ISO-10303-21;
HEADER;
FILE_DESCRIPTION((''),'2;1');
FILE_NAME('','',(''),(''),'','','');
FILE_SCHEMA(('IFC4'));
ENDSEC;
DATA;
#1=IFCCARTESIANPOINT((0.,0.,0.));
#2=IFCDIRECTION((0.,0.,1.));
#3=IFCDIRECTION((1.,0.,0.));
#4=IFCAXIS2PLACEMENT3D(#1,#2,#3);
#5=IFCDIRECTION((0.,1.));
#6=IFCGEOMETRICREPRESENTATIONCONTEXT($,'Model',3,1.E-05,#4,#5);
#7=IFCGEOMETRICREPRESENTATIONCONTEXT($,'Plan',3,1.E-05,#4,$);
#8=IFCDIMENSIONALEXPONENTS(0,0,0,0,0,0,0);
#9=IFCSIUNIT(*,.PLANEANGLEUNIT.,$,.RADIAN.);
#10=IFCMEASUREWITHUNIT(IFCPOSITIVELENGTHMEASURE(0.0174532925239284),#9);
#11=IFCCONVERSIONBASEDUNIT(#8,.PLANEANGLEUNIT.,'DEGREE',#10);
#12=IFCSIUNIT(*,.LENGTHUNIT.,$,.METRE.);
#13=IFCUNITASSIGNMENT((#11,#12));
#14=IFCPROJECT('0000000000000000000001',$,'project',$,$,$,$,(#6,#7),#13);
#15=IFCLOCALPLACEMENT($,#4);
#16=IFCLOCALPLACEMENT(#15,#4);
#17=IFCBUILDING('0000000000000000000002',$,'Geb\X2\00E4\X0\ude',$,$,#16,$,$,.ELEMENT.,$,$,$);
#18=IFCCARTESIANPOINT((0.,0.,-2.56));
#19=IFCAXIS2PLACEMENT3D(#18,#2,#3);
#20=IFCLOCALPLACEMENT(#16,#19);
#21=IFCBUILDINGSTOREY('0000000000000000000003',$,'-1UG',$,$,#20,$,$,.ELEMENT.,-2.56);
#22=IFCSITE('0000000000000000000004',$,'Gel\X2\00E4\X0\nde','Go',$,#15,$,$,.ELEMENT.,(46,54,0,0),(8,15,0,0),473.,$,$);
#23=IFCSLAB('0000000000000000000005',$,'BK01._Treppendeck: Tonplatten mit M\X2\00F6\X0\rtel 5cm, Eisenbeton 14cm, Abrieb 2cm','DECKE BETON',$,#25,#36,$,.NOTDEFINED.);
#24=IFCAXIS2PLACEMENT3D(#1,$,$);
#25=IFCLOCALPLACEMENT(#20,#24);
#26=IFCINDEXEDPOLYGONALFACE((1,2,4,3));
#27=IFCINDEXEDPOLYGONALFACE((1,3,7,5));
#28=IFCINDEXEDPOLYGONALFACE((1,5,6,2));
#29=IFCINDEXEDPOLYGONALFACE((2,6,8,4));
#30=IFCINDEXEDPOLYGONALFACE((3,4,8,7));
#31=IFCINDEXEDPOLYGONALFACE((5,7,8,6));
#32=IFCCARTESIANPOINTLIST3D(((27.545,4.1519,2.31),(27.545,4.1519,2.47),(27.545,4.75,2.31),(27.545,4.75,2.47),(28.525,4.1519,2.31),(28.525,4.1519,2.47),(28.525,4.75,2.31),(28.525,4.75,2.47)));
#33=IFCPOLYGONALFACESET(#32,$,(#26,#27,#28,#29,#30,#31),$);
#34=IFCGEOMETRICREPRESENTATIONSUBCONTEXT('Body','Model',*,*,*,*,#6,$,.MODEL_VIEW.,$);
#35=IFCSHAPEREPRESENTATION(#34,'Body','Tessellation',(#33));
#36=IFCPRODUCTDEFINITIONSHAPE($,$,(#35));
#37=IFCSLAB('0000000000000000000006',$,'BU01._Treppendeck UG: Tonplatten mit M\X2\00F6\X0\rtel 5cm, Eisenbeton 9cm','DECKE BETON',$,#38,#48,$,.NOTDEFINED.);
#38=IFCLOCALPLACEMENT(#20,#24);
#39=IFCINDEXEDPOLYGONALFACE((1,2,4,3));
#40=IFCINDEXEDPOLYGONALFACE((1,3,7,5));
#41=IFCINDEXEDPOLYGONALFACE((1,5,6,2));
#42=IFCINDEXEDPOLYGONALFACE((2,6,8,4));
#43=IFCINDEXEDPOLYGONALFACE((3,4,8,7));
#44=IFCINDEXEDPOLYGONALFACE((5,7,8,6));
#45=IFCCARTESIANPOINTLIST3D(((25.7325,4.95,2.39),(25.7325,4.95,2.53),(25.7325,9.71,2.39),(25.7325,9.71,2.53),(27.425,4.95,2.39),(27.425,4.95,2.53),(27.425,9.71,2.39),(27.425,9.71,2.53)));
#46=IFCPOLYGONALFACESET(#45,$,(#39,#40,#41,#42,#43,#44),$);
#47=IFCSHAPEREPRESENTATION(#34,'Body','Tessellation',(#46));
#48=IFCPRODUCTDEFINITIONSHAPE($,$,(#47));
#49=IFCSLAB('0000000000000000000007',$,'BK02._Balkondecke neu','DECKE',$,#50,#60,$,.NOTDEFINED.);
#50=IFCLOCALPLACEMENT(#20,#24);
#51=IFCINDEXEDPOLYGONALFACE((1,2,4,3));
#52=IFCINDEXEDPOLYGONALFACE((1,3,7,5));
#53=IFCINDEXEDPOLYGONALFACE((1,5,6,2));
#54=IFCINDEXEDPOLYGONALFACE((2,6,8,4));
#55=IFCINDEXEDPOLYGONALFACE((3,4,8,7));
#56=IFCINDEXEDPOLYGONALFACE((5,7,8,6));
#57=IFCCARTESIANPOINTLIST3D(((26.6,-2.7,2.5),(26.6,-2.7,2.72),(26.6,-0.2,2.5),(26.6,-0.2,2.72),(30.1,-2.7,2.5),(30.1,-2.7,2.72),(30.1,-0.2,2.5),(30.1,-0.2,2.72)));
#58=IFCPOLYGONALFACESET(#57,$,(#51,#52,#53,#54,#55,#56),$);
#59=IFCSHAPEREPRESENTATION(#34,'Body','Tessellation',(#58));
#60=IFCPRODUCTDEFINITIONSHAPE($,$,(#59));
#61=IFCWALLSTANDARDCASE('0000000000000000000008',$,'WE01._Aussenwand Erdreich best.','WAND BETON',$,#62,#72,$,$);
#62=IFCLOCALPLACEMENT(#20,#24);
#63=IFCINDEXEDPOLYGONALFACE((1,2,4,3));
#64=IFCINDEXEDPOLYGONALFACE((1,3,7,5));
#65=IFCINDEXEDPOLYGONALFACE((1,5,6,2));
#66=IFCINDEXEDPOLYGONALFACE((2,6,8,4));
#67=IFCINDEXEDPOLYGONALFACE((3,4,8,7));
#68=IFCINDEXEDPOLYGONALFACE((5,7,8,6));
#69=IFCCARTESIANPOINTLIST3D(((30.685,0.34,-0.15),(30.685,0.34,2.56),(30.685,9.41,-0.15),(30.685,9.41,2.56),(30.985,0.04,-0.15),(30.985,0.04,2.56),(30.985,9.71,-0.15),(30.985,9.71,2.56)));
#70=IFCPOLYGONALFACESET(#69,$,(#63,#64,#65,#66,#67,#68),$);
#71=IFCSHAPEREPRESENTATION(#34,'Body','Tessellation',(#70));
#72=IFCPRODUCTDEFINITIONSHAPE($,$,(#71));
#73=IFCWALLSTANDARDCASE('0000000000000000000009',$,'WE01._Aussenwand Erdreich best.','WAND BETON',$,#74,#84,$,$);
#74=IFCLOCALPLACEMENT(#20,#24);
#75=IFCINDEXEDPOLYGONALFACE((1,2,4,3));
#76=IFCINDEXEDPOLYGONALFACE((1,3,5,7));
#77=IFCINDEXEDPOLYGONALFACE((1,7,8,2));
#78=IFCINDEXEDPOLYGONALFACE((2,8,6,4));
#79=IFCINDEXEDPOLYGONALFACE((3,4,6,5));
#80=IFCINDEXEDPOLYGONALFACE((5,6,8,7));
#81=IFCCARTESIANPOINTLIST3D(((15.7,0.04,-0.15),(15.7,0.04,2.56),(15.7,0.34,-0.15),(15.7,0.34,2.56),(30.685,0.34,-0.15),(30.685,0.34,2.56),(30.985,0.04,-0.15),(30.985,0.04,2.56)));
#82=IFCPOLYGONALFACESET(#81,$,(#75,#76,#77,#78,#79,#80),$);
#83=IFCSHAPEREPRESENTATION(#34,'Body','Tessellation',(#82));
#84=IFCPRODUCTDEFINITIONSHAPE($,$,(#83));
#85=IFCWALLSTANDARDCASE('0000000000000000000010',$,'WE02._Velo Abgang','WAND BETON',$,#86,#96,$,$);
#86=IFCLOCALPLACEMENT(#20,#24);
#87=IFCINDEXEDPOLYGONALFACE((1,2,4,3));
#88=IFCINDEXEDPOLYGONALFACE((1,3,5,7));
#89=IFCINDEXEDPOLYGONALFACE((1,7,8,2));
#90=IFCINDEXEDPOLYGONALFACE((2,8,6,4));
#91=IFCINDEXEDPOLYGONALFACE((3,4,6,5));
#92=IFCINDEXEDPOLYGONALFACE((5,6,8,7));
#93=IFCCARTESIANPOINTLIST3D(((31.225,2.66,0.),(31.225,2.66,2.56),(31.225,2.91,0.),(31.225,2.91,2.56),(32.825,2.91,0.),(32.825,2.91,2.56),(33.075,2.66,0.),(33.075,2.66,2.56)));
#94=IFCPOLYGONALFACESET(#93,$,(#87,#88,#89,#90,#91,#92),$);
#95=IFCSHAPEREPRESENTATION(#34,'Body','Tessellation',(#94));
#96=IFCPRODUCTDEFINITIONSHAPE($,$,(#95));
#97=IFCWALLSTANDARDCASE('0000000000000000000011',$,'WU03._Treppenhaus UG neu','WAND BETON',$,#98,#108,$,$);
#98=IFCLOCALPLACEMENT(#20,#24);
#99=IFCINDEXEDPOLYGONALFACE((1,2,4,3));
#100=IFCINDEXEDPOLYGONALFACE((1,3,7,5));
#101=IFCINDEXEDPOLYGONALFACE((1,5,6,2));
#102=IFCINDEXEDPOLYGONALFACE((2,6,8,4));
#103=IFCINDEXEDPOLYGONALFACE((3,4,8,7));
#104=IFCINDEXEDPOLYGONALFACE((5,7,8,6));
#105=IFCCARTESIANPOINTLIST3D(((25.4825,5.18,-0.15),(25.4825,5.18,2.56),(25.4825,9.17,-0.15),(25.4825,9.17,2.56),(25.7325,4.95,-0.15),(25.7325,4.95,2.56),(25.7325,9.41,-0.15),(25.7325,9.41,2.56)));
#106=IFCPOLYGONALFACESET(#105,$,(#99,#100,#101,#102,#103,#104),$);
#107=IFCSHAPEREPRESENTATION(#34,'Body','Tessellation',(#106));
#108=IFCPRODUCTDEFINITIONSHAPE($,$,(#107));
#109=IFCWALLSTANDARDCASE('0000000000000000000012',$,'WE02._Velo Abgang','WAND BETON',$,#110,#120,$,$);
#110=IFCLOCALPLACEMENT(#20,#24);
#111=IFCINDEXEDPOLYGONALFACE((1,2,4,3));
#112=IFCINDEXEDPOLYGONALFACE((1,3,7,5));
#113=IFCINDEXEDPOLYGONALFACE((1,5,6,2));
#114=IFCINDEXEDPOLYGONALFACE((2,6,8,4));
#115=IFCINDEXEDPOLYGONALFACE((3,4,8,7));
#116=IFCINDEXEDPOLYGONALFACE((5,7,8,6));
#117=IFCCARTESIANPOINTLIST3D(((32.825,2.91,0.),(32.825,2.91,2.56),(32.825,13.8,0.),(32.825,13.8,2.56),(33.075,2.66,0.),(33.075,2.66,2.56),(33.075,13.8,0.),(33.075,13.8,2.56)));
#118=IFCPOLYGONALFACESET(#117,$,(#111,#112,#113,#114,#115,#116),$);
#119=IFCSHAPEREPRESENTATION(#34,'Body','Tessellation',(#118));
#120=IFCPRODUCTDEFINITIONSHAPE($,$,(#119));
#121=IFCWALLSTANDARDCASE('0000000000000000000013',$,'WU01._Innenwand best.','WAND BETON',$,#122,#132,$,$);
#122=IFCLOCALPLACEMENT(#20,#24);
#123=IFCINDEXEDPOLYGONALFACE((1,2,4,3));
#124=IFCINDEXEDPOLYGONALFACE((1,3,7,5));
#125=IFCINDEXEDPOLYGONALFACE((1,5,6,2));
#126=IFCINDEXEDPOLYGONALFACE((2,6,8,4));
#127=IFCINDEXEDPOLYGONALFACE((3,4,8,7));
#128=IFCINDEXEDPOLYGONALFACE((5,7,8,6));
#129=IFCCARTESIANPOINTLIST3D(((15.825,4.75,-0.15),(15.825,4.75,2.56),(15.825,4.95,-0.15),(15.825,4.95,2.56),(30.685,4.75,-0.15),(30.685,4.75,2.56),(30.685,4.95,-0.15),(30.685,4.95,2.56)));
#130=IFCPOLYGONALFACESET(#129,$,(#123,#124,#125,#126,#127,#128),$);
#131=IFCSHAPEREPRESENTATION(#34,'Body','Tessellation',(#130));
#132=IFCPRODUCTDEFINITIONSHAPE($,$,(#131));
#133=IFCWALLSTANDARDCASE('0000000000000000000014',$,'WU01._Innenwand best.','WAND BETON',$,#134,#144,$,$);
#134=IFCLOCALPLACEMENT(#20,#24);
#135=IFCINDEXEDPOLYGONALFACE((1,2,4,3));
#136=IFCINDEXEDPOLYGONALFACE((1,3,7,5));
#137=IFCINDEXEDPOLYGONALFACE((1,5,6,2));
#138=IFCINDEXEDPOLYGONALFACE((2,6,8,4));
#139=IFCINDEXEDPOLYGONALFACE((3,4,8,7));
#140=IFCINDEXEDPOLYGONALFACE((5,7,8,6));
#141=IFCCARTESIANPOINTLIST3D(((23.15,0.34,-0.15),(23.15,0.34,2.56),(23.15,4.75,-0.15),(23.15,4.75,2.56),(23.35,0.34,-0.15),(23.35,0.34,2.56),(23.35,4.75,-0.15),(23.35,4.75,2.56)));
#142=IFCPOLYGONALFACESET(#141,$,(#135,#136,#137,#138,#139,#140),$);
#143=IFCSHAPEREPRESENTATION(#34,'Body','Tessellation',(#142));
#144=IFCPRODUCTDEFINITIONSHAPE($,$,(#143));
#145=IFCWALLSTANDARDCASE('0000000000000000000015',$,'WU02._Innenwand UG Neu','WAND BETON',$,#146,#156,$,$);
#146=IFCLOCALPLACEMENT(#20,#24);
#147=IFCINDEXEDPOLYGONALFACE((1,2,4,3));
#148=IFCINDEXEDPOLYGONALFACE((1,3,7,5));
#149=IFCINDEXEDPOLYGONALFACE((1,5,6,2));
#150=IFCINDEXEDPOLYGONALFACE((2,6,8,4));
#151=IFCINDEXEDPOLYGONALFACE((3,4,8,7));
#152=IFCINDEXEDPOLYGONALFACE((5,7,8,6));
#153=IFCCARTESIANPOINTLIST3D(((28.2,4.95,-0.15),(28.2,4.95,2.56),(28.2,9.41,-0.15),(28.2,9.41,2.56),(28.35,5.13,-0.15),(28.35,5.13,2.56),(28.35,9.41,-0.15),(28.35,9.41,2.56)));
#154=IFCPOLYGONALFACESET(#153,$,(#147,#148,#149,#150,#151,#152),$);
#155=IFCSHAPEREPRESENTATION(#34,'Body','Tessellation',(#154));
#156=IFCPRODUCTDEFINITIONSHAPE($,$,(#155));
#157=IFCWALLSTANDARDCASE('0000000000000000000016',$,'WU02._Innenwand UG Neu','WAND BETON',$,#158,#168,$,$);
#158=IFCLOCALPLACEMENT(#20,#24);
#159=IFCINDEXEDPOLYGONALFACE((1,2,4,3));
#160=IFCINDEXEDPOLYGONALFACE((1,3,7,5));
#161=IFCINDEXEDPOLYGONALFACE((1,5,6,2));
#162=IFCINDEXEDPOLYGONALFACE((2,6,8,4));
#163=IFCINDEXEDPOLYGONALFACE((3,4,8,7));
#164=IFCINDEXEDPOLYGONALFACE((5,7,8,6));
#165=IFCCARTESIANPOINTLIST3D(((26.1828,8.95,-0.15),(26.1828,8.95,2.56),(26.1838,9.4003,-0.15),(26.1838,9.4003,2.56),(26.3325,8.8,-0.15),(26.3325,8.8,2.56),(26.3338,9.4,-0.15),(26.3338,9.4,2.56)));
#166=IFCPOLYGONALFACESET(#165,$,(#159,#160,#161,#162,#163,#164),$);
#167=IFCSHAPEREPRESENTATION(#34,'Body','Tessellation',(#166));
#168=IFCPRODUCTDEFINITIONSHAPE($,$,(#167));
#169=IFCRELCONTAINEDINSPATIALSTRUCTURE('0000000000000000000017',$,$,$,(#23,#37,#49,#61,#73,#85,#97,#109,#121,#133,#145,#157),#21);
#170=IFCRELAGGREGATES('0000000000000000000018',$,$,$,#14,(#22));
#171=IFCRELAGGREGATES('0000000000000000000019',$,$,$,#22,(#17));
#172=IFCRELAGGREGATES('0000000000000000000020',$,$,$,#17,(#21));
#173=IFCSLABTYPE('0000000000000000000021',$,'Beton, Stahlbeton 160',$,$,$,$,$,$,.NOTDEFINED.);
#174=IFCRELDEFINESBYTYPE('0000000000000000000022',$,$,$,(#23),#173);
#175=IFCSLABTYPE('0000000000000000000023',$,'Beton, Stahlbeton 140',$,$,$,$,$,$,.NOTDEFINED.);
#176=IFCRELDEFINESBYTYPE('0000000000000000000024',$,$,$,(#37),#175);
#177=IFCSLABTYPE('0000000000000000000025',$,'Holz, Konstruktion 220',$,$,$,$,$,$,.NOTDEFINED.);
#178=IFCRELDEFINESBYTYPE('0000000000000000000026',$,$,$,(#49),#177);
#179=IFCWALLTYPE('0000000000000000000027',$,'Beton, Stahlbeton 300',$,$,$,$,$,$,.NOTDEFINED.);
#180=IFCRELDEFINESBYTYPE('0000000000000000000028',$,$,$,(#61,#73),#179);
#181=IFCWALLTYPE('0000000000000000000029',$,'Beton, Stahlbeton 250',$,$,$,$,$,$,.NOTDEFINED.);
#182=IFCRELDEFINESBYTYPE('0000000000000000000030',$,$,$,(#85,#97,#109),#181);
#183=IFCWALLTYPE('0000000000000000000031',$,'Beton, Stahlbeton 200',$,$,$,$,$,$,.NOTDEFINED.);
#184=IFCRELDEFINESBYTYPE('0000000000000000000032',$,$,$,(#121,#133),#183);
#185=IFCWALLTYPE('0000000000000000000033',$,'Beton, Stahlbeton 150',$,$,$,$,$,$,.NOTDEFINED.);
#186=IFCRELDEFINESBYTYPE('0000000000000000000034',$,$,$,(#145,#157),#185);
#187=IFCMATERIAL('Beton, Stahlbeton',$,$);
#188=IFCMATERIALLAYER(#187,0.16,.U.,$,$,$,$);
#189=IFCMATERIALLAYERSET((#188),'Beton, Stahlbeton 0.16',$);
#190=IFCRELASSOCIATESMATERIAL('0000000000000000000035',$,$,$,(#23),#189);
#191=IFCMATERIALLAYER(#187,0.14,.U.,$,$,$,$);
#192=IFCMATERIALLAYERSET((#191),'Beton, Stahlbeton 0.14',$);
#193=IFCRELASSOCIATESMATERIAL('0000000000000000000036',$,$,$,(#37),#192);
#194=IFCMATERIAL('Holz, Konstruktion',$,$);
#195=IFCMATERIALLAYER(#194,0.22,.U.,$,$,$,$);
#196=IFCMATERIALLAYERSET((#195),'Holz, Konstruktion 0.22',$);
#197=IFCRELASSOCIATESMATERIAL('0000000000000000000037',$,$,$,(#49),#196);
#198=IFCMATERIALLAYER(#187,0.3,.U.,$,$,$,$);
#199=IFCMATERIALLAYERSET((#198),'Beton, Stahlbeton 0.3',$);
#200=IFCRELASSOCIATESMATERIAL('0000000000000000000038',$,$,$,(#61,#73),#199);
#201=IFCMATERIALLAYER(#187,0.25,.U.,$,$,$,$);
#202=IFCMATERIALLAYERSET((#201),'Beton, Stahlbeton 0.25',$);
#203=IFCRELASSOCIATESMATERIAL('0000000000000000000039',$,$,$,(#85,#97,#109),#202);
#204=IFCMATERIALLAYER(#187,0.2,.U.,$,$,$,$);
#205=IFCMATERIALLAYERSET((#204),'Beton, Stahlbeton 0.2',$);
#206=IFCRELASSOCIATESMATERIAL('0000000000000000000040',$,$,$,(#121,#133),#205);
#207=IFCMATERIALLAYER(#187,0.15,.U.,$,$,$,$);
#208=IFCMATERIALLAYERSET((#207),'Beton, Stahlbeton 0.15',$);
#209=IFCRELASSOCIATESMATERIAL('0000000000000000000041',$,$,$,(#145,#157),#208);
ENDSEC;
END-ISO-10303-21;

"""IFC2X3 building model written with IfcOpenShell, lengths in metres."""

from ifc_helpers import new_model, entity, si_unit, converted_unit, direction, frame, origin_with_axes, place, context, subcontext, project, spatial, polyline, outline, extrude, material, layer, layer_set, layer_usage, type_object, element, save


model = new_model("IFC2X3")

# Units and contexts
model_context = context("Model", 3, precision=1e-05, world=origin_with_axes(), true_north=direction((0.0, 1.0)))
plan_context = context("Plan", 3, precision=1e-05, world=origin_with_axes())
body_context = subcontext(model_context, "Body", "Model", "MODEL_VIEW")
ifc_project = project(units=[converted_unit("PLANEANGLEUNIT", "DEGREE", entity("IfcPositiveLengthMeasure", 0.0174532925239284), si_unit("PLANEANGLEUNIT", "RADIAN"), dimensions=[0, 0, 0, 0, 0, 0, 0]), si_unit("LENGTHUNIT", "METRE")], contexts=[model_context, plan_context])

# Site, building, storey
site_placement = place(None, origin_with_axes())
site = spatial("IfcSite", under=ifc_project, at=site_placement, Name="Gelände", Description="Go", CompositionType="ELEMENT", RefLatitude=(46, 54, 0, 0), RefLongitude=(8, 15, 0, 0), RefElevation=473.0)
building_placement = place(site_placement, origin_with_axes())
building = spatial("IfcBuilding", under=site, at=building_placement, Name="Gebäude", CompositionType="ELEMENT")
storey_placement = place(building_placement, frame((0.0, 0.0, -2.56), z_axis=(0.0, 0.0, 1.0), x_axis=(1.0, 0.0, 0.0)))
storey = spatial("IfcBuildingStorey", under=building, at=storey_placement, Name="-1UG", CompositionType="ELEMENT", Elevation=-2.56)

# Slabs
ifc_material_1 = material(Name="Beton, Stahlbeton")
ifc_layer_1 = layer(ifc_material_1, 0.16, ventilated="UNKNOWN")
ifc_layer_set_1 = layer_set([ifc_layer_1], Name="Beton, Stahlbeton 0.16")
ifc_layer_usage_1 = layer_usage(ifc_layer_set_1, "AXIS3", "NEGATIVE", 0.16)
slab_type_1 = type_object("IfcSlabType", Name="Beton, Stahlbeton 160", PredefinedType="NOTDEFINED")
slab_1_placement = place(storey_placement, frame((27.545, 4.1519, 2.47), z_axis=(0.0, 0.0, 1.0), x_axis=(1.0, 0.0, 0.0)))
element("IfcSlab", 1, at=slab_1_placement, inside=storey, type_object=slab_type_1, material=ifc_layer_usage_1, Name="BK01._Treppendeck: Tonplatten mit Mörtel 5cm, Eisenbeton 14cm, Abrieb 2cm", Description="DECKE BETON", PredefinedType="NOTDEFINED", context=body_context, shape_type="SweptSolid", body=[
    extrude(outline(polyline([(0.0, 0.0), (0.98, 0.0), (0.98, 0.5981), (0.0, 0.5981), (0.0, 0.0)])), frame((0.0, 0.0, -0.16), z_axis=(0.0, 0.0, 1.0), x_axis=(1.0, 0.0, 0.0)), (0.0, 0.0, 1.0), 0.16),
])
ifc_layer_2 = layer(ifc_material_1, 0.14, ventilated="UNKNOWN")
ifc_layer_set_2 = layer_set([ifc_layer_2], Name="Beton, Stahlbeton 0.14")
ifc_layer_usage_2 = layer_usage(ifc_layer_set_2, "AXIS3", "NEGATIVE", 0.14)
slab_type_2 = type_object("IfcSlabType", Name="Beton, Stahlbeton 140", PredefinedType="NOTDEFINED")
slab_2_placement = place(storey_placement, frame((25.7325, 4.95, 2.53), z_axis=(0.0, 0.0, 1.0), x_axis=(1.0, 0.0, 0.0)))
element("IfcSlab", 2, at=slab_2_placement, inside=storey, type_object=slab_type_2, material=ifc_layer_usage_2, Name="BU01._Treppendeck UG: Tonplatten mit Mörtel 5cm, Eisenbeton 9cm", Description="DECKE BETON", PredefinedType="NOTDEFINED", context=body_context, shape_type="SweptSolid", body=[
    extrude(outline(polyline([(0.0, 0.0), (1.6925, 0.0), (1.6925, 4.76), (0.0, 4.76), (0.0, 0.0)])), frame((0.0, 0.0, -0.14), z_axis=(0.0, 0.0, 1.0), x_axis=(1.0, 0.0, 0.0)), (0.0, 0.0, 1.0), 0.14),
])
ifc_material_2 = material(Name="Holz, Konstruktion")
ifc_layer_3 = layer(ifc_material_2, 0.22, ventilated="UNKNOWN")
ifc_layer_set_3 = layer_set([ifc_layer_3], Name="Holz, Konstruktion 0.22")
ifc_layer_usage_3 = layer_usage(ifc_layer_set_3, "AXIS3", "NEGATIVE", 0.22)
slab_type_3 = type_object("IfcSlabType", Name="Holz, Konstruktion 220", PredefinedType="NOTDEFINED")
slab_3_placement = place(storey_placement, frame((26.6, -2.7, 2.72), z_axis=(0.0, 0.0, 1.0), x_axis=(1.0, 0.0, 0.0)))
element("IfcSlab", 3, at=slab_3_placement, inside=storey, type_object=slab_type_3, material=ifc_layer_usage_3, Name="BK02._Balkondecke neu", Description="DECKE", PredefinedType="NOTDEFINED", context=body_context, shape_type="SweptSolid", body=[
    extrude(outline(polyline([(0.0, 0.0), (3.5, 0.0), (3.5, 2.5), (0.0, 2.5), (0.0, 0.0)])), frame((0.0, 0.0, -0.22), z_axis=(0.0, 0.0, 1.0), x_axis=(1.0, 0.0, 0.0)), (0.0, 0.0, 1.0), 0.22),
])

# Walls
ifc_layer_4 = layer(ifc_material_1, 0.3, ventilated="UNKNOWN")
ifc_layer_set_4 = layer_set([ifc_layer_4], Name="Beton, Stahlbeton 0.3")
ifc_layer_usage_4 = layer_usage(ifc_layer_set_4, "AXIS2", "NEGATIVE", 0.3)
wall_type_1 = type_object("IfcWallType", Name="Beton, Stahlbeton 300", PredefinedType="NOTDEFINED")
wall_1_placement = place(storey_placement, frame((30.685, 9.41, -0.15), z_axis=(0.0, 0.0, 1.0), x_axis=(0.0, -1.0, 0.0)))
element("IfcWallStandardCase", 4, at=wall_1_placement, inside=storey, type_object=wall_type_1, material=ifc_layer_usage_4, Name="WE01._Aussenwand Erdreich best.", Description="WAND BETON", context=body_context, shape_type="SweptSolid", body=[
    extrude(outline(polyline([(0.0, 0.0), (9.07, 0.0), (9.37, 0.3), (-0.3, 0.3), (0.0, 0.0)])), origin_with_axes(), (0.0, 0.0, 1.0), 2.71),
])
ifc_layer_usage_5 = layer_usage(ifc_layer_set_4, "AXIS2", "NEGATIVE", 0.3)
wall_2_placement = place(storey_placement, frame((30.685, 0.34, -0.15), z_axis=(0.0, 0.0, 1.0), x_axis=(-1.0, 0.0, 0.0)))
element("IfcWallStandardCase", 5, at=wall_2_placement, inside=storey, type_object=wall_type_1, material=ifc_layer_usage_5, Name="WE01._Aussenwand Erdreich best.", Description="WAND BETON", context=body_context, shape_type="SweptSolid", body=[
    extrude(outline(polyline([(0.0, 0.0), (14.985, 0.0), (14.985, 0.3), (-0.3, 0.3), (0.0, 0.0)])), origin_with_axes(), (0.0, 0.0, 1.0), 2.71),
])
ifc_layer_5 = layer(ifc_material_1, 0.25, ventilated="UNKNOWN")
ifc_layer_set_5 = layer_set([ifc_layer_5], Name="Beton, Stahlbeton 0.25")
ifc_layer_usage_6 = layer_usage(ifc_layer_set_5, "AXIS2", "NEGATIVE", 0.0)
wall_type_2 = type_object("IfcWallType", Name="Beton, Stahlbeton 250", PredefinedType="NOTDEFINED")
wall_3_placement = place(storey_placement, frame((33.075, 2.66, 0.0), z_axis=(0.0, 0.0, 1.0), x_axis=(-1.0, 0.0, 0.0)))
element("IfcWallStandardCase", 6, at=wall_3_placement, inside=storey, type_object=wall_type_2, material=ifc_layer_usage_6, Name="WE02._Velo Abgang", Description="WAND BETON", context=body_context, shape_type="SweptSolid", body=[
    extrude(outline(polyline([(0.25, -0.25), (1.85, -0.25), (1.85, 0.0), (0.0, 0.0), (0.25, -0.25)])), origin_with_axes(), (0.0, 0.0, 1.0), 2.56),
])
ifc_layer_usage_7 = layer_usage(ifc_layer_set_5, "AXIS2", "NEGATIVE", 0.25)
wall_4_placement = place(storey_placement, frame((25.4825, 9.17, -0.15), z_axis=(0.0, 0.0, 1.0), x_axis=(0.0, -1.0, 0.0)))
element("IfcWallStandardCase", 7, at=wall_4_placement, inside=storey, type_object=wall_type_2, material=ifc_layer_usage_7, Name="WU03._Treppenhaus UG neu", Description="WAND BETON", context=body_context, shape_type="SweptSolid", body=[
    extrude(outline(polyline([(0.0, 0.0), (3.99, 0.0), (4.22, 0.25), (-0.24, 0.25), (0.0, 0.0)])), origin_with_axes(), (0.0, 0.0, 1.0), 2.71),
])
ifc_layer_usage_8 = layer_usage(ifc_layer_set_5, "AXIS2", "NEGATIVE", 0.0)
wall_5_placement = place(storey_placement, frame((33.075, 13.8, 0.0), z_axis=(0.0, 0.0, 1.0), x_axis=(0.0, -1.0, 0.0)))
element("IfcWallStandardCase", 8, at=wall_5_placement, inside=storey, type_object=wall_type_2, material=ifc_layer_usage_8, Name="WE02._Velo Abgang", Description="WAND BETON", context=body_context, shape_type="SweptSolid", body=[
    extrude(outline(polyline([(0.0, -0.25), (10.89, -0.25), (11.14, 0.0), (0.0, 0.0), (0.0, -0.25)])), origin_with_axes(), (0.0, 0.0, 1.0), 2.56),
])
ifc_layer_6 = layer(ifc_material_1, 0.2, ventilated="UNKNOWN")
ifc_layer_set_6 = layer_set([ifc_layer_6], Name="Beton, Stahlbeton 0.2")
ifc_layer_usage_9 = layer_usage(ifc_layer_set_6, "AXIS2", "POSITIVE", 0.0)
wall_type_3 = type_object("IfcWallType", Name="Beton, Stahlbeton 200", PredefinedType="NOTDEFINED")
wall_6_placement = place(storey_placement, frame((30.685, 4.95, -0.15), z_axis=(0.0, 0.0, 1.0), x_axis=(-1.0, 0.0, 0.0)))
element("IfcWallStandardCase", 9, at=wall_6_placement, inside=storey, type_object=wall_type_3, material=ifc_layer_usage_9, Name="WU01._Innenwand best.", Description="WAND BETON", context=body_context, shape_type="SweptSolid", body=[
    extrude(outline(polyline([(0.0, 0.0), (14.86, 0.0), (14.86, 0.2), (0.0, 0.2), (0.0, 0.0)])), origin_with_axes(), (0.0, 0.0, 1.0), 2.71),
])
ifc_layer_usage_10 = layer_usage(ifc_layer_set_6, "AXIS2", "NEGATIVE", 0.0)
wall_7_placement = place(storey_placement, frame((23.15, 0.34, -0.15), z_axis=(0.0, 0.0, 1.0), x_axis=(0.0, 1.0, 0.0)))
element("IfcWallStandardCase", 10, at=wall_7_placement, inside=storey, type_object=wall_type_3, material=ifc_layer_usage_10, Name="WU01._Innenwand best.", Description="WAND BETON", context=body_context, shape_type="SweptSolid", body=[
    extrude(outline(polyline([(0.0, -0.2), (4.41, -0.2), (4.41, 0.0), (0.0, 0.0), (0.0, -0.2)])), origin_with_axes(), (0.0, 0.0, 1.0), 2.71),
])
ifc_layer_7 = layer(ifc_material_1, 0.15, ventilated="UNKNOWN")
ifc_layer_set_7 = layer_set([ifc_layer_7], Name="Beton, Stahlbeton 0.15")
ifc_layer_usage_11 = layer_usage(ifc_layer_set_7, "AXIS2", "POSITIVE", 0.0)
wall_type_4 = type_object("IfcWallType", Name="Beton, Stahlbeton 150", PredefinedType="NOTDEFINED")
wall_8_placement = place(storey_placement, frame((28.2, 9.41, -0.15), z_axis=(0.0, 0.0, 1.0), x_axis=(0.0, -1.0, 0.0)))
element("IfcWallStandardCase", 11, at=wall_8_placement, inside=storey, type_object=wall_type_4, material=ifc_layer_usage_11, Name="WU02._Innenwand UG Neu", Description="WAND BETON", context=body_context, shape_type="SweptSolid", body=[
    extrude(outline(polyline([(0.0, 0.0), (4.46, 0.0), (4.28, 0.15), (0.0, 0.15), (0.0, 0.0)])), origin_with_axes(), (0.0, 0.0, 1.0), 2.71),
])
ifc_layer_usage_12 = layer_usage(ifc_layer_set_7, "AXIS2", "NEGATIVE", 0.0)
wall_9_placement = place(storey_placement, frame((26.3338, 9.4, -0.15), z_axis=(0.0, 0.0, 1.0), x_axis=(-0.002118, -0.999998, 0.0)))
element("IfcWallStandardCase", 12, at=wall_9_placement, inside=storey, type_object=wall_type_4, material=ifc_layer_usage_12, Name="WU02._Innenwand UG Neu", Description="WAND BETON", context=body_context, shape_type="SweptSolid", body=[
    extrude(outline(polyline([(0.0, -0.15), (0.4503, -0.15), (0.6, 0.0), (0.0, 0.0), (0.0, -0.15)])), origin_with_axes(), (0.0, 0.0, 1.0), 2.71),
])

save(model, "model.ifc")
